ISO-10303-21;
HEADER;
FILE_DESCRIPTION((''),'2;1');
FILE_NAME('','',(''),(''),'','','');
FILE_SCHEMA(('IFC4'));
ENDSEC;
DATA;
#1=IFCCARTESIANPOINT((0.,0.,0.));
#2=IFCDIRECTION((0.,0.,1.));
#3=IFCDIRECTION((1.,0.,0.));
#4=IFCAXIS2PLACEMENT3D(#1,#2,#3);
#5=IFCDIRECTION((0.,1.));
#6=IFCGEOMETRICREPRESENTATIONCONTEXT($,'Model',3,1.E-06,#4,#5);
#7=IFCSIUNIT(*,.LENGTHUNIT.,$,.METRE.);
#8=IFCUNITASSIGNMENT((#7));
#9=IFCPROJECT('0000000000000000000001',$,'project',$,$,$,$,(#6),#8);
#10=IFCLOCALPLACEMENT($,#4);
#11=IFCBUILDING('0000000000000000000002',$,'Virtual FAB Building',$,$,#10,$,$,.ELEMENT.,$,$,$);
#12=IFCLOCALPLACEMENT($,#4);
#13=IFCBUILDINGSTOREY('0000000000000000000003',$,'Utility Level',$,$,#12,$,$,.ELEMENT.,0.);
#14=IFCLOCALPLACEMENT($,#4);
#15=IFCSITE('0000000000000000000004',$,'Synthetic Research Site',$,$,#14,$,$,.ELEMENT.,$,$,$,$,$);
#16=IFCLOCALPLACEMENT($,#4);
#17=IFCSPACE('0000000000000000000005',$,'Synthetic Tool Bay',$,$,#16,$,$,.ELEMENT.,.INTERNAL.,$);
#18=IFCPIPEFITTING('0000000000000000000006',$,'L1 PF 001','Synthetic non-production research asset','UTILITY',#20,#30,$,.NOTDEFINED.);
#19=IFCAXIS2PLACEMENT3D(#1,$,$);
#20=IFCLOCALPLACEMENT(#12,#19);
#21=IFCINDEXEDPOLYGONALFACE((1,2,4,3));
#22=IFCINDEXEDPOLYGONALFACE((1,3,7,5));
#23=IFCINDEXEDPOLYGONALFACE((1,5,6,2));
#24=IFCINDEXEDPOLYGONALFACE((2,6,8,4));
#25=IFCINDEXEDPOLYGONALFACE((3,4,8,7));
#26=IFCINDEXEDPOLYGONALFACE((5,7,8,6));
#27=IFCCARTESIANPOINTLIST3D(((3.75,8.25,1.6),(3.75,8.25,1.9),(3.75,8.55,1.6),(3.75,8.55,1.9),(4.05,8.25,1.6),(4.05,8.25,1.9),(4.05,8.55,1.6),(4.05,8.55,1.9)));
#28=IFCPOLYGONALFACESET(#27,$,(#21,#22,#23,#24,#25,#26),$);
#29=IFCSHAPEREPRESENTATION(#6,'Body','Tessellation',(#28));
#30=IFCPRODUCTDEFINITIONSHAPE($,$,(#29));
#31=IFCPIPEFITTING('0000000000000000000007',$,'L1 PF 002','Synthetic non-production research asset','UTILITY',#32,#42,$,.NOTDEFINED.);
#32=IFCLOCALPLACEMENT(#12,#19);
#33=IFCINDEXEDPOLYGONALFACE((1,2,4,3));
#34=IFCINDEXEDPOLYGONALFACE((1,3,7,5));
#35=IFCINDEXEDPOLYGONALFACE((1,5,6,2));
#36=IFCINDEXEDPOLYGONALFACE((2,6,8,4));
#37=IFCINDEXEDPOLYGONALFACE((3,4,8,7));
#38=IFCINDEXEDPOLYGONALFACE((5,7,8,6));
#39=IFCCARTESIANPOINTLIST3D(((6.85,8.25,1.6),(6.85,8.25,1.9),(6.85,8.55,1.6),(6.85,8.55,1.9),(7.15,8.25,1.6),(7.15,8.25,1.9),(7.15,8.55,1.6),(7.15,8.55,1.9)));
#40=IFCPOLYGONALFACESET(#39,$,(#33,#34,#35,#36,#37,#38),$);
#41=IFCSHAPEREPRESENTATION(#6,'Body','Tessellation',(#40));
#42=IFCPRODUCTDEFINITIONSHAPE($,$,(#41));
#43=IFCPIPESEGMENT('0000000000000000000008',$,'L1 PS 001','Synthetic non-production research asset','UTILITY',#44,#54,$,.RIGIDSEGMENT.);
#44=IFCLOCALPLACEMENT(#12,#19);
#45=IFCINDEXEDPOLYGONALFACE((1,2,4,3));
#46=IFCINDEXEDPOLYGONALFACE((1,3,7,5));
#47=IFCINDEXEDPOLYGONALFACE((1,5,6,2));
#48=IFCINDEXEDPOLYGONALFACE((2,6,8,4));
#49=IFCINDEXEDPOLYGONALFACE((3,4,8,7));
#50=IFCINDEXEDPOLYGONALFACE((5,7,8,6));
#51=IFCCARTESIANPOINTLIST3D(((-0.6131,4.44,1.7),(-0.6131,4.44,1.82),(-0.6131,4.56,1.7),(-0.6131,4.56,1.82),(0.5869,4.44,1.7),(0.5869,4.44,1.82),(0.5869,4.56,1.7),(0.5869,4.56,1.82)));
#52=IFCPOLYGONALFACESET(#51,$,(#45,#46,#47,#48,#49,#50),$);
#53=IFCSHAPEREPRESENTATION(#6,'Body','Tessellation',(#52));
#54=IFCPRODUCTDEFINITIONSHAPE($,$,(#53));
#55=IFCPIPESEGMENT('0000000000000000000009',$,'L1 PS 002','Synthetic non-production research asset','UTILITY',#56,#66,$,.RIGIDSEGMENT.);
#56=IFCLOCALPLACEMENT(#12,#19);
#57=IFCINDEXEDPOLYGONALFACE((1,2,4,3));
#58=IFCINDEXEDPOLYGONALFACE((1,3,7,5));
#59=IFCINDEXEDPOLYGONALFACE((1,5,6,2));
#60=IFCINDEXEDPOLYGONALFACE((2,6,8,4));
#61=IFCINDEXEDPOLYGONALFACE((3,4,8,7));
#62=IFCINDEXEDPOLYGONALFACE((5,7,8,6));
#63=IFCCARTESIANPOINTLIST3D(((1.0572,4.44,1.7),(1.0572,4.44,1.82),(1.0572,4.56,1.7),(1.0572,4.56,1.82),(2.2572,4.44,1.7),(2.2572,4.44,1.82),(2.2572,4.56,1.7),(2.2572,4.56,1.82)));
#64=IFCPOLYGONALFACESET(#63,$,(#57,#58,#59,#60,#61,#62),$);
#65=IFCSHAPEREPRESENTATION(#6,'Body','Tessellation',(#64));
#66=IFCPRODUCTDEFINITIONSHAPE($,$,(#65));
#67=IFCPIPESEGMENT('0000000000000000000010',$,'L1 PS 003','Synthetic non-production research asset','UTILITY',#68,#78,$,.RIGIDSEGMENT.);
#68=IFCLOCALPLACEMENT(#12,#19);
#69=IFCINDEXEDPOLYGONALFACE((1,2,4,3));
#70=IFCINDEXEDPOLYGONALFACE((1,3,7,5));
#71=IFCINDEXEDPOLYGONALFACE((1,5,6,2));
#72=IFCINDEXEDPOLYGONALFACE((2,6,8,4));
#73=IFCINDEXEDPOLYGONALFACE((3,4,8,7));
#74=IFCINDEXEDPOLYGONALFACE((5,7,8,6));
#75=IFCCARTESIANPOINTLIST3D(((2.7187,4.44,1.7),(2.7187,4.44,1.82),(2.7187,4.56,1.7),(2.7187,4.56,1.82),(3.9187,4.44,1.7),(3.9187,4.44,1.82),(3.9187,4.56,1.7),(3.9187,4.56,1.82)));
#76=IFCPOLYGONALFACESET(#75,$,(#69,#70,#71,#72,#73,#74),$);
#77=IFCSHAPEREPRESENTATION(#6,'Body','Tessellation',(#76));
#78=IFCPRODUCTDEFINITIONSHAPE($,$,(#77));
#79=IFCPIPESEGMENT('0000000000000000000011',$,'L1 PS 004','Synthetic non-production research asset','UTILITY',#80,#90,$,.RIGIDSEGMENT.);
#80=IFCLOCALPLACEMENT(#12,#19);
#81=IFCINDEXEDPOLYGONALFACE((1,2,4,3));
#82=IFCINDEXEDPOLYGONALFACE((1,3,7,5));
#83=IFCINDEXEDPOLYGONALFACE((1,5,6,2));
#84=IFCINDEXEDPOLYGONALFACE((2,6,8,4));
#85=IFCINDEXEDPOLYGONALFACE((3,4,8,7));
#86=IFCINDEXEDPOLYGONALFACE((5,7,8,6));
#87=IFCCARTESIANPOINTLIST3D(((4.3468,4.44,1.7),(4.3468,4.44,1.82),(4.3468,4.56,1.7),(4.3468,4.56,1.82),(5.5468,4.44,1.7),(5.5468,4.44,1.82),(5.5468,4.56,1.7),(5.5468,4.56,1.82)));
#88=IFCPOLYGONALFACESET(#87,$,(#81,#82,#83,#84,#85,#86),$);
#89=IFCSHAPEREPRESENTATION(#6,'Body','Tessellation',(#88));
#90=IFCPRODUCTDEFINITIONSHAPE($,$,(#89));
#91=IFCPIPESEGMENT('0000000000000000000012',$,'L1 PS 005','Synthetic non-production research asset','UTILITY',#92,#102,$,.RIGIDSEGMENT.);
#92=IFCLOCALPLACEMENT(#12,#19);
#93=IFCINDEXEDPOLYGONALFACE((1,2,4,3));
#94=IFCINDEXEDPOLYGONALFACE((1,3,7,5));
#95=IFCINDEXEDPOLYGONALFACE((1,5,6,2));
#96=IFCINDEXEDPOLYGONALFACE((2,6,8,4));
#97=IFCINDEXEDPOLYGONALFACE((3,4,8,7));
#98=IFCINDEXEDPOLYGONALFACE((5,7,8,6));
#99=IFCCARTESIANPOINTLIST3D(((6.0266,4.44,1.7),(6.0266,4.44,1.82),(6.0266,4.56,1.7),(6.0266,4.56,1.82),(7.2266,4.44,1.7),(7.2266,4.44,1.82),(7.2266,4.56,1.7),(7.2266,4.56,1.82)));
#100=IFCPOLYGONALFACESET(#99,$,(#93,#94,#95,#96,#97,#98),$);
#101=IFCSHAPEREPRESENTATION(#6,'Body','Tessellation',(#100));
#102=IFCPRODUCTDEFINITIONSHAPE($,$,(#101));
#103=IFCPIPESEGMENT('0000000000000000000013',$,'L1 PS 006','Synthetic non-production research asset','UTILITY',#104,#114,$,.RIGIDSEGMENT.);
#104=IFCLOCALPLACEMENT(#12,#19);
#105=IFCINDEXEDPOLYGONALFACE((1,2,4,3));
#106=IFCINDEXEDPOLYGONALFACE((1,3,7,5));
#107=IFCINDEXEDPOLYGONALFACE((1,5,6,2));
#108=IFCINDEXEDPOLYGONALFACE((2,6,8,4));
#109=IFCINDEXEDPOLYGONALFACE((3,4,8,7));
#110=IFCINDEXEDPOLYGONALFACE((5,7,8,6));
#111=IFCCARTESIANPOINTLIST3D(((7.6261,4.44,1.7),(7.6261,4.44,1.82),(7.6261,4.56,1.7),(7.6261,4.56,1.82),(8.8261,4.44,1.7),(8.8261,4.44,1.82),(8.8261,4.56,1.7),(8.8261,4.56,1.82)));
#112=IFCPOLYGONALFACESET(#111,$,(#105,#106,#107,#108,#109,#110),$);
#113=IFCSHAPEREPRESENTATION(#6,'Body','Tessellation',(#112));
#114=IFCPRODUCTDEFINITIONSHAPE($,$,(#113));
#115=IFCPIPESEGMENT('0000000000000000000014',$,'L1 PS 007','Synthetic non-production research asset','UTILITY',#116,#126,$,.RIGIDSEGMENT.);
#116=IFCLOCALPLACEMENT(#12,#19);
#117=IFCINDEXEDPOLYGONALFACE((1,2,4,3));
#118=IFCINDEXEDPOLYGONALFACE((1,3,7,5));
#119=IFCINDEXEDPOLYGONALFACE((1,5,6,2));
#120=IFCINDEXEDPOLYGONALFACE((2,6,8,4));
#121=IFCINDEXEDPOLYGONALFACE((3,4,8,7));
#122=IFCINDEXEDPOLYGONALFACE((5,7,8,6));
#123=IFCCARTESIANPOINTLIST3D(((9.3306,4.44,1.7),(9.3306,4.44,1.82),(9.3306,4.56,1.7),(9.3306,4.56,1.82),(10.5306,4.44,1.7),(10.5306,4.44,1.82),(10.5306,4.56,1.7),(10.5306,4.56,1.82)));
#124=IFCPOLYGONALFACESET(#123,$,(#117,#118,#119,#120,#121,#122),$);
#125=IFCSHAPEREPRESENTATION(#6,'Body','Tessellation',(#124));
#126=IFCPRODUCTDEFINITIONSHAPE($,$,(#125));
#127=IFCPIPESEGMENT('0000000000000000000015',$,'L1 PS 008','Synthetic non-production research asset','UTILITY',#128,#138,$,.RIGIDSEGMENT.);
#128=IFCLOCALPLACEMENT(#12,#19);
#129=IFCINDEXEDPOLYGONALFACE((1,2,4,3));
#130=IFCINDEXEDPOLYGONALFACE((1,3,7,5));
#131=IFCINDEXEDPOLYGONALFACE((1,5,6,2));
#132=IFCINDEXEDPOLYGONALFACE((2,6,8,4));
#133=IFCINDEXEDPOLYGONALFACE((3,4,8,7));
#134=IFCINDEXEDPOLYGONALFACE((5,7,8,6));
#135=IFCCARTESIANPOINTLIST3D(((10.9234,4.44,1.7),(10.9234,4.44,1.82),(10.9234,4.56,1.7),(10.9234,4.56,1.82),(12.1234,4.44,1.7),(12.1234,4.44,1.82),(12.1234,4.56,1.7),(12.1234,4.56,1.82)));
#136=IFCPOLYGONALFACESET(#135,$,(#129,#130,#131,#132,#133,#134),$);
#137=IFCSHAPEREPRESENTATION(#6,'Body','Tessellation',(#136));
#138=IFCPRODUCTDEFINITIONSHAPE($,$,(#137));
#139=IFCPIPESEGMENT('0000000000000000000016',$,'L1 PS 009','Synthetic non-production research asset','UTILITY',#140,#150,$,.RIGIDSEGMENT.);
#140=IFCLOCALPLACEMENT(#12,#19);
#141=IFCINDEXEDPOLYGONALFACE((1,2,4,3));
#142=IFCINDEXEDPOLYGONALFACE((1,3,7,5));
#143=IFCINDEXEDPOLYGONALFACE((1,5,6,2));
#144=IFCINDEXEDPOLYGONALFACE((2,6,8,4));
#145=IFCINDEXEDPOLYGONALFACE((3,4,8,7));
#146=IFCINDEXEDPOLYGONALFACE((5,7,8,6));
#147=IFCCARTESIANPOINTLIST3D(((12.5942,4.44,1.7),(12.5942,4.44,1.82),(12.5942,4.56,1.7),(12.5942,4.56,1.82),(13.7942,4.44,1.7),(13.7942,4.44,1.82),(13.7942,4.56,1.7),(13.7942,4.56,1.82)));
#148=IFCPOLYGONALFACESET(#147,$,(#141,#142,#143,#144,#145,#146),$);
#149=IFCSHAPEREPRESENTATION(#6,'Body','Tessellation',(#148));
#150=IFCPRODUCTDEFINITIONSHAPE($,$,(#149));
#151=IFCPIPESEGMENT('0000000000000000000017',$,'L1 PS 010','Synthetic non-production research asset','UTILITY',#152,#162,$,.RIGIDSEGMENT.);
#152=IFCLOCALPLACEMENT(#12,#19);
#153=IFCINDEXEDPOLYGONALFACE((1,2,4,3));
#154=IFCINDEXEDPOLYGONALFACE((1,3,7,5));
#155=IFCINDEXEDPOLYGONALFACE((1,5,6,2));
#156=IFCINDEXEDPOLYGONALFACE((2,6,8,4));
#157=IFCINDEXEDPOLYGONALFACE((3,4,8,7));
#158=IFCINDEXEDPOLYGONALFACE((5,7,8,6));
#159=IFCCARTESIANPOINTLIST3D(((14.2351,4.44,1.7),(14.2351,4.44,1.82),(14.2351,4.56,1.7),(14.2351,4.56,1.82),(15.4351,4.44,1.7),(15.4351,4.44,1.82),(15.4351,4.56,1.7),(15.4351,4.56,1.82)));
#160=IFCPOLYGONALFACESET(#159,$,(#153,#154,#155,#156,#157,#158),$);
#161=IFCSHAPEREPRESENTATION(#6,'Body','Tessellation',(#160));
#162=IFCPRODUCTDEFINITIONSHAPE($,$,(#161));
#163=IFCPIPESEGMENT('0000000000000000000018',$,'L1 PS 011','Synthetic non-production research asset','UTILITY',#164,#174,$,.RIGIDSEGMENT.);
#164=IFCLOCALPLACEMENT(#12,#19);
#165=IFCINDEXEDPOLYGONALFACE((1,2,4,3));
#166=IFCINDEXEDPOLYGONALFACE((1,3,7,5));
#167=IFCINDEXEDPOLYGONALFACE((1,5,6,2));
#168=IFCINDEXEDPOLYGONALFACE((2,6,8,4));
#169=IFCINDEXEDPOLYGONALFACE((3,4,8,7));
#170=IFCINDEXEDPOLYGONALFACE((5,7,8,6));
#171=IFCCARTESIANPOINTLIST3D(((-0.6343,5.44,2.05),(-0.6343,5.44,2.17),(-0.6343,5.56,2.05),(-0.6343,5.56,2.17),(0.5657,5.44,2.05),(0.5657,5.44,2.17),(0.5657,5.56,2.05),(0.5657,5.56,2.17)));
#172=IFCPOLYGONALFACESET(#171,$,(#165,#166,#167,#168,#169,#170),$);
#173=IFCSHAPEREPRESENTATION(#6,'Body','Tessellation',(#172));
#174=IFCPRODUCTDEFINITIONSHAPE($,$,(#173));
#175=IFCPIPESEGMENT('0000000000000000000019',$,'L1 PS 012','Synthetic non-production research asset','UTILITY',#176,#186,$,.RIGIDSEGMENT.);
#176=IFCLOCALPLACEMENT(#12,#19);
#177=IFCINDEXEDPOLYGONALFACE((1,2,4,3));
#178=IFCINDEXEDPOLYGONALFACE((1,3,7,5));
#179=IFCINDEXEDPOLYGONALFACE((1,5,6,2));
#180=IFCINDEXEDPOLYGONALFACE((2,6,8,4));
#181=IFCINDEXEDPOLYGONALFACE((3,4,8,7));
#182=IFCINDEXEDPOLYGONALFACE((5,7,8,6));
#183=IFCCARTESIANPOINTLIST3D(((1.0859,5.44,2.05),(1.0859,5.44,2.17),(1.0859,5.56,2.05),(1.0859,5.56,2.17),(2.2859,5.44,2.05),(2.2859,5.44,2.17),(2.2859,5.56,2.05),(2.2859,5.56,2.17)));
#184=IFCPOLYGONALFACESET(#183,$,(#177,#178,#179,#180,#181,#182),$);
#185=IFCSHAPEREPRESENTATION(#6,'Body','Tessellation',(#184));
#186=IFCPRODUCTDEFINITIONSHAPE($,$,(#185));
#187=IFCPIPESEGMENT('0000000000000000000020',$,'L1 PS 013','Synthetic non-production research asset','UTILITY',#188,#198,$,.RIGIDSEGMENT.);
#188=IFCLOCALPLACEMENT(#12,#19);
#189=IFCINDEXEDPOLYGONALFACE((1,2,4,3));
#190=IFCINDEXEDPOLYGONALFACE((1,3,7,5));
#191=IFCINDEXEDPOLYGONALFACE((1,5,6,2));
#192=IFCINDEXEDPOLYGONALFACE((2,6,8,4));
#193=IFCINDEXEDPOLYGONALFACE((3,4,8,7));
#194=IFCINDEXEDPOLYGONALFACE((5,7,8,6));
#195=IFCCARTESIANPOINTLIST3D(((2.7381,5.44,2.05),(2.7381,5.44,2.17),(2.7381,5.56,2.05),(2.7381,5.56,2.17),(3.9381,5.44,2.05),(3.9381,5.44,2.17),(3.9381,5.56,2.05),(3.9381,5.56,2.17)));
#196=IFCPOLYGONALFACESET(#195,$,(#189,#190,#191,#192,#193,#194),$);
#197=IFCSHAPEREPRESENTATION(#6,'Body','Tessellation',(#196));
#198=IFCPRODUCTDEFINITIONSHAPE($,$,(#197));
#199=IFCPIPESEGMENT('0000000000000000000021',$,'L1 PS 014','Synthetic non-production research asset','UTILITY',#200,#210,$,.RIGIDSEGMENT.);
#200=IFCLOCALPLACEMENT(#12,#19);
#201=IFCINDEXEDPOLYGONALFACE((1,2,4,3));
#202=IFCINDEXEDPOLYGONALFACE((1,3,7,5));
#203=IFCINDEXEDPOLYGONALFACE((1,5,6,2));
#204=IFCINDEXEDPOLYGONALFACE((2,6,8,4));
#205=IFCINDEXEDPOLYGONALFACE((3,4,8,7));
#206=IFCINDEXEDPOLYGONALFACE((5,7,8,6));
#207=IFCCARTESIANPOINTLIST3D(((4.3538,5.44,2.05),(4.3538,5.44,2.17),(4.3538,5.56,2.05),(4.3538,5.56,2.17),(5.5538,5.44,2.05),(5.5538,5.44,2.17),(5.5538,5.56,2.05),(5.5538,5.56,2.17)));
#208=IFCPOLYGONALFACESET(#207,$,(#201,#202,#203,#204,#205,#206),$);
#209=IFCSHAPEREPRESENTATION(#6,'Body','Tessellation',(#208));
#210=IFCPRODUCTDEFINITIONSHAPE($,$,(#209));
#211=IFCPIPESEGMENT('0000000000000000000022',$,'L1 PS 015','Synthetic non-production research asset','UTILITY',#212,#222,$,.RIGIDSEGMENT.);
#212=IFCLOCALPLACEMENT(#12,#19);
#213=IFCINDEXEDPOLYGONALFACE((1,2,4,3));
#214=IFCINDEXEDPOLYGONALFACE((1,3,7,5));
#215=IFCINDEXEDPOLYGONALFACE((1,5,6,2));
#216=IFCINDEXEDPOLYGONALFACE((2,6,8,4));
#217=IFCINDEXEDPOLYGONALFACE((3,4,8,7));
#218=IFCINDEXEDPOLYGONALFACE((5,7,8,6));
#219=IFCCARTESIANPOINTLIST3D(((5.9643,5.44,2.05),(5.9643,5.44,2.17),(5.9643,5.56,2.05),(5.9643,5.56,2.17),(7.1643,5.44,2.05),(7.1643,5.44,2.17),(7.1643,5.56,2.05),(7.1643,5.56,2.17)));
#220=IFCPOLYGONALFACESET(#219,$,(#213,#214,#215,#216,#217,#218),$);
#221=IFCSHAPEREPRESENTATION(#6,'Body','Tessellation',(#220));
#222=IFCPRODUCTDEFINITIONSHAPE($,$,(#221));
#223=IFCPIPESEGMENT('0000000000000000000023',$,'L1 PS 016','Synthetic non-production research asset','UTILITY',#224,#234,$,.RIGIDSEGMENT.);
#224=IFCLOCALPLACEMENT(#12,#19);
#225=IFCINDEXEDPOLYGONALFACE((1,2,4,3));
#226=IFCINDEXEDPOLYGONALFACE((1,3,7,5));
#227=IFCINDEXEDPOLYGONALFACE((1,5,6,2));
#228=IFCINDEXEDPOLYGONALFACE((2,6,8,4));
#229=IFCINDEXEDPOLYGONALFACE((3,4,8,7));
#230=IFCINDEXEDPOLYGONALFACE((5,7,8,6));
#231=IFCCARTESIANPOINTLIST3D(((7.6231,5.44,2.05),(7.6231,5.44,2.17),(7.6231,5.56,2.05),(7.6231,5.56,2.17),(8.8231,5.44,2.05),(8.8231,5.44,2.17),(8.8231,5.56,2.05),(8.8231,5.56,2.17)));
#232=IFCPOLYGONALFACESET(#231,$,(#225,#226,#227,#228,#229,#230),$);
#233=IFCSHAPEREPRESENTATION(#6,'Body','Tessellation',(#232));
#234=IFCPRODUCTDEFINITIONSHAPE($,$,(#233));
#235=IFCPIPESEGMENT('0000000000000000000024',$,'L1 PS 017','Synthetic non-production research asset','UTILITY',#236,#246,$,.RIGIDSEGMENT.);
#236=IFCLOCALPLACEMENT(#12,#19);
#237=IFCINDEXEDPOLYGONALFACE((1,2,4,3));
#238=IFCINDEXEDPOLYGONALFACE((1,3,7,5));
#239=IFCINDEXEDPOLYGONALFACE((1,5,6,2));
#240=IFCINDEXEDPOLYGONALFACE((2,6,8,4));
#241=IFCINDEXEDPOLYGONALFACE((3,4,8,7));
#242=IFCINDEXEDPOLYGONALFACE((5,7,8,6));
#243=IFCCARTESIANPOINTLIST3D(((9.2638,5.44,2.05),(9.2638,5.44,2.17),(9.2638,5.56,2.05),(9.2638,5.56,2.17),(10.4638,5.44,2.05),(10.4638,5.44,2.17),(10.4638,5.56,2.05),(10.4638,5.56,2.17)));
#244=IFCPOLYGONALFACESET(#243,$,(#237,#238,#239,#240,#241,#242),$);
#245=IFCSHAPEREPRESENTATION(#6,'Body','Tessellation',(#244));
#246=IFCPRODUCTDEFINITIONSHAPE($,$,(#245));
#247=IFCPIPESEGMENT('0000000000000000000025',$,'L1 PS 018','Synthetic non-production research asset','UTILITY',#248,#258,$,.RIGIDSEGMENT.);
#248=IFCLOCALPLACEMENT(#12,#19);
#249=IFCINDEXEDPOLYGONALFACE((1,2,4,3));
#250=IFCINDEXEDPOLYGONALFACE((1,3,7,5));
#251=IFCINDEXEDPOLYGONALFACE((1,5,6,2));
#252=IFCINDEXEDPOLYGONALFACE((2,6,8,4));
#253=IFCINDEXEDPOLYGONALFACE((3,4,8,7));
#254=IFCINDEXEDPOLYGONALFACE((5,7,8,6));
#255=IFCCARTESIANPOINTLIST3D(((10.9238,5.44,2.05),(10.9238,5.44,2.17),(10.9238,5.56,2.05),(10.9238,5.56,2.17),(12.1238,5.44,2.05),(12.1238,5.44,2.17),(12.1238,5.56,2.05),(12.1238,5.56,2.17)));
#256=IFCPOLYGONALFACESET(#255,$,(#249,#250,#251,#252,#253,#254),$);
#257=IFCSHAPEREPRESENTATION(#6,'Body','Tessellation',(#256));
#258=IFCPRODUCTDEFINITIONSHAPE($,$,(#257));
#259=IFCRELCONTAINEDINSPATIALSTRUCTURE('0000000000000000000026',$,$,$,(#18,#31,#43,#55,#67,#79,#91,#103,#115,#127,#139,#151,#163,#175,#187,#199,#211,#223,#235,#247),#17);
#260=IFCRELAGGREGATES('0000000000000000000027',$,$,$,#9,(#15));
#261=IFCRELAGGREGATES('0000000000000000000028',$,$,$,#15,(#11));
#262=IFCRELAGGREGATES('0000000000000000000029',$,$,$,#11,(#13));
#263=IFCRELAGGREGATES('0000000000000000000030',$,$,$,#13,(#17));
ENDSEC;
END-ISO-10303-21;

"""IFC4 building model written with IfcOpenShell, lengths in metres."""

from ifc_helpers import new_model, si_unit, direction, frame, origin_with_axes, origin_2d_with_axis, place, context, project, spatial, rectangle, extrude, element, save


model = new_model("IFC4")

# Units and contexts
model_context = context("Model", 3, precision=1e-06, world=origin_with_axes(), true_north=direction((0.0, 1.0)))
ifc_project = project(units=[si_unit("LENGTHUNIT", "METRE")], contexts=[model_context])

# Site, building, storey, space
site_placement = place(None, origin_with_axes())
site = spatial("IfcSite", under=ifc_project, at=site_placement, Name="Synthetic Research Site", CompositionType="ELEMENT")
building_placement = place(None, origin_with_axes())
building = spatial("IfcBuilding", under=site, at=building_placement, Name="Virtual FAB Building", CompositionType="ELEMENT")
storey_placement = place(None, origin_with_axes())
storey = spatial("IfcBuildingStorey", under=building, at=storey_placement, Name="Utility Level", CompositionType="ELEMENT", Elevation=0.0)
space_placement = place(None, origin_with_axes())
space = spatial("IfcSpace", under=storey, at=space_placement, Name="Synthetic Tool Bay", CompositionType="ELEMENT", PredefinedType="INTERNAL")

# Pipe fittings
for number, where, z_axis, x_axis, name in (
    (1, (3.9, 8.4, 1.6), (0.0, 0.0, 1.0), (1.0, 0.0, 0.0), "L1 PF 001"),
    (2, (7.0, 8.4, 1.6), (0.0, 0.0, 1.0), (1.0, 0.0, 0.0), "L1 PF 002"),
):
    element("IfcPipeFitting", number, at=place(None, frame(where, z_axis=z_axis, x_axis=x_axis)), inside=space, Name=name, Description="Synthetic non-production research asset", ObjectType="UTILITY", PredefinedType="NOTDEFINED", context=model_context, shape_type="SweptSolid", body=[
        extrude(rectangle(XDim=0.3, YDim=0.3, at=origin_2d_with_axis()), origin_with_axes(), (0.0, 0.0, 1.0), 0.3),
    ])

# Pipe segments
for number, where, z_axis, x_axis, name in (
    (3, (-0.0131, 4.5, 1.7), (0.0, 0.0, 1.0), (1.0, 0.0, 0.0), "L1 PS 001"),
    (4, (1.6572, 4.5, 1.7), (0.0, 0.0, 1.0), (1.0, 0.0, 0.0), "L1 PS 002"),
    (5, (3.3187, 4.5, 1.7), (0.0, 0.0, 1.0), (1.0, 0.0, 0.0), "L1 PS 003"),
    (6, (4.9468, 4.5, 1.7), (0.0, 0.0, 1.0), (1.0, 0.0, 0.0), "L1 PS 004"),
    (7, (6.6266, 4.5, 1.7), (0.0, 0.0, 1.0), (1.0, 0.0, 0.0), "L1 PS 005"),
    (8, (8.2261, 4.5, 1.7), (0.0, 0.0, 1.0), (1.0, 0.0, 0.0), "L1 PS 006"),
    (9, (9.9306, 4.5, 1.7), (0.0, 0.0, 1.0), (1.0, 0.0, 0.0), "L1 PS 007"),
    (10, (11.5234, 4.5, 1.7), (0.0, 0.0, 1.0), (1.0, 0.0, 0.0), "L1 PS 008"),
    (11, (13.1942, 4.5, 1.7), (0.0, 0.0, 1.0), (1.0, 0.0, 0.0), "L1 PS 009"),
    (12, (14.8351, 4.5, 1.7), (0.0, 0.0, 1.0), (1.0, 0.0, 0.0), "L1 PS 010"),
    (13, (-0.0343, 5.5, 2.05), (0.0, 0.0, 1.0), (1.0, 0.0, 0.0), "L1 PS 011"),
    (14, (1.6859, 5.5, 2.05), (0.0, 0.0, 1.0), (1.0, 0.0, 0.0), "L1 PS 012"),
    (15, (3.3381, 5.5, 2.05), (0.0, 0.0, 1.0), (1.0, 0.0, 0.0), "L1 PS 013"),
    (16, (4.9538, 5.5, 2.05), (0.0, 0.0, 1.0), (1.0, 0.0, 0.0), "L1 PS 014"),
    (17, (6.5643, 5.5, 2.05), (0.0, 0.0, 1.0), (1.0, 0.0, 0.0), "L1 PS 015"),
    (18, (8.2231, 5.5, 2.05), (0.0, 0.0, 1.0), (1.0, 0.0, 0.0), "L1 PS 016"),
    (19, (9.8638, 5.5, 2.05), (0.0, 0.0, 1.0), (1.0, 0.0, 0.0), "L1 PS 017"),
    (20, (11.5238, 5.5, 2.05), (0.0, 0.0, 1.0), (1.0, 0.0, 0.0), "L1 PS 018"),
):
    element("IfcPipeSegment", number, at=place(None, frame(where, z_axis=z_axis, x_axis=x_axis)), inside=space, Name=name, Description="Synthetic non-production research asset", ObjectType="UTILITY", PredefinedType="RIGIDSEGMENT", context=model_context, shape_type="SweptSolid", body=[
        extrude(rectangle(XDim=1.2, YDim=0.12, at=origin_2d_with_axis()), origin_with_axes(), (0.0, 0.0, 1.0), 0.12),
    ])

save(model, "model.ifc")
